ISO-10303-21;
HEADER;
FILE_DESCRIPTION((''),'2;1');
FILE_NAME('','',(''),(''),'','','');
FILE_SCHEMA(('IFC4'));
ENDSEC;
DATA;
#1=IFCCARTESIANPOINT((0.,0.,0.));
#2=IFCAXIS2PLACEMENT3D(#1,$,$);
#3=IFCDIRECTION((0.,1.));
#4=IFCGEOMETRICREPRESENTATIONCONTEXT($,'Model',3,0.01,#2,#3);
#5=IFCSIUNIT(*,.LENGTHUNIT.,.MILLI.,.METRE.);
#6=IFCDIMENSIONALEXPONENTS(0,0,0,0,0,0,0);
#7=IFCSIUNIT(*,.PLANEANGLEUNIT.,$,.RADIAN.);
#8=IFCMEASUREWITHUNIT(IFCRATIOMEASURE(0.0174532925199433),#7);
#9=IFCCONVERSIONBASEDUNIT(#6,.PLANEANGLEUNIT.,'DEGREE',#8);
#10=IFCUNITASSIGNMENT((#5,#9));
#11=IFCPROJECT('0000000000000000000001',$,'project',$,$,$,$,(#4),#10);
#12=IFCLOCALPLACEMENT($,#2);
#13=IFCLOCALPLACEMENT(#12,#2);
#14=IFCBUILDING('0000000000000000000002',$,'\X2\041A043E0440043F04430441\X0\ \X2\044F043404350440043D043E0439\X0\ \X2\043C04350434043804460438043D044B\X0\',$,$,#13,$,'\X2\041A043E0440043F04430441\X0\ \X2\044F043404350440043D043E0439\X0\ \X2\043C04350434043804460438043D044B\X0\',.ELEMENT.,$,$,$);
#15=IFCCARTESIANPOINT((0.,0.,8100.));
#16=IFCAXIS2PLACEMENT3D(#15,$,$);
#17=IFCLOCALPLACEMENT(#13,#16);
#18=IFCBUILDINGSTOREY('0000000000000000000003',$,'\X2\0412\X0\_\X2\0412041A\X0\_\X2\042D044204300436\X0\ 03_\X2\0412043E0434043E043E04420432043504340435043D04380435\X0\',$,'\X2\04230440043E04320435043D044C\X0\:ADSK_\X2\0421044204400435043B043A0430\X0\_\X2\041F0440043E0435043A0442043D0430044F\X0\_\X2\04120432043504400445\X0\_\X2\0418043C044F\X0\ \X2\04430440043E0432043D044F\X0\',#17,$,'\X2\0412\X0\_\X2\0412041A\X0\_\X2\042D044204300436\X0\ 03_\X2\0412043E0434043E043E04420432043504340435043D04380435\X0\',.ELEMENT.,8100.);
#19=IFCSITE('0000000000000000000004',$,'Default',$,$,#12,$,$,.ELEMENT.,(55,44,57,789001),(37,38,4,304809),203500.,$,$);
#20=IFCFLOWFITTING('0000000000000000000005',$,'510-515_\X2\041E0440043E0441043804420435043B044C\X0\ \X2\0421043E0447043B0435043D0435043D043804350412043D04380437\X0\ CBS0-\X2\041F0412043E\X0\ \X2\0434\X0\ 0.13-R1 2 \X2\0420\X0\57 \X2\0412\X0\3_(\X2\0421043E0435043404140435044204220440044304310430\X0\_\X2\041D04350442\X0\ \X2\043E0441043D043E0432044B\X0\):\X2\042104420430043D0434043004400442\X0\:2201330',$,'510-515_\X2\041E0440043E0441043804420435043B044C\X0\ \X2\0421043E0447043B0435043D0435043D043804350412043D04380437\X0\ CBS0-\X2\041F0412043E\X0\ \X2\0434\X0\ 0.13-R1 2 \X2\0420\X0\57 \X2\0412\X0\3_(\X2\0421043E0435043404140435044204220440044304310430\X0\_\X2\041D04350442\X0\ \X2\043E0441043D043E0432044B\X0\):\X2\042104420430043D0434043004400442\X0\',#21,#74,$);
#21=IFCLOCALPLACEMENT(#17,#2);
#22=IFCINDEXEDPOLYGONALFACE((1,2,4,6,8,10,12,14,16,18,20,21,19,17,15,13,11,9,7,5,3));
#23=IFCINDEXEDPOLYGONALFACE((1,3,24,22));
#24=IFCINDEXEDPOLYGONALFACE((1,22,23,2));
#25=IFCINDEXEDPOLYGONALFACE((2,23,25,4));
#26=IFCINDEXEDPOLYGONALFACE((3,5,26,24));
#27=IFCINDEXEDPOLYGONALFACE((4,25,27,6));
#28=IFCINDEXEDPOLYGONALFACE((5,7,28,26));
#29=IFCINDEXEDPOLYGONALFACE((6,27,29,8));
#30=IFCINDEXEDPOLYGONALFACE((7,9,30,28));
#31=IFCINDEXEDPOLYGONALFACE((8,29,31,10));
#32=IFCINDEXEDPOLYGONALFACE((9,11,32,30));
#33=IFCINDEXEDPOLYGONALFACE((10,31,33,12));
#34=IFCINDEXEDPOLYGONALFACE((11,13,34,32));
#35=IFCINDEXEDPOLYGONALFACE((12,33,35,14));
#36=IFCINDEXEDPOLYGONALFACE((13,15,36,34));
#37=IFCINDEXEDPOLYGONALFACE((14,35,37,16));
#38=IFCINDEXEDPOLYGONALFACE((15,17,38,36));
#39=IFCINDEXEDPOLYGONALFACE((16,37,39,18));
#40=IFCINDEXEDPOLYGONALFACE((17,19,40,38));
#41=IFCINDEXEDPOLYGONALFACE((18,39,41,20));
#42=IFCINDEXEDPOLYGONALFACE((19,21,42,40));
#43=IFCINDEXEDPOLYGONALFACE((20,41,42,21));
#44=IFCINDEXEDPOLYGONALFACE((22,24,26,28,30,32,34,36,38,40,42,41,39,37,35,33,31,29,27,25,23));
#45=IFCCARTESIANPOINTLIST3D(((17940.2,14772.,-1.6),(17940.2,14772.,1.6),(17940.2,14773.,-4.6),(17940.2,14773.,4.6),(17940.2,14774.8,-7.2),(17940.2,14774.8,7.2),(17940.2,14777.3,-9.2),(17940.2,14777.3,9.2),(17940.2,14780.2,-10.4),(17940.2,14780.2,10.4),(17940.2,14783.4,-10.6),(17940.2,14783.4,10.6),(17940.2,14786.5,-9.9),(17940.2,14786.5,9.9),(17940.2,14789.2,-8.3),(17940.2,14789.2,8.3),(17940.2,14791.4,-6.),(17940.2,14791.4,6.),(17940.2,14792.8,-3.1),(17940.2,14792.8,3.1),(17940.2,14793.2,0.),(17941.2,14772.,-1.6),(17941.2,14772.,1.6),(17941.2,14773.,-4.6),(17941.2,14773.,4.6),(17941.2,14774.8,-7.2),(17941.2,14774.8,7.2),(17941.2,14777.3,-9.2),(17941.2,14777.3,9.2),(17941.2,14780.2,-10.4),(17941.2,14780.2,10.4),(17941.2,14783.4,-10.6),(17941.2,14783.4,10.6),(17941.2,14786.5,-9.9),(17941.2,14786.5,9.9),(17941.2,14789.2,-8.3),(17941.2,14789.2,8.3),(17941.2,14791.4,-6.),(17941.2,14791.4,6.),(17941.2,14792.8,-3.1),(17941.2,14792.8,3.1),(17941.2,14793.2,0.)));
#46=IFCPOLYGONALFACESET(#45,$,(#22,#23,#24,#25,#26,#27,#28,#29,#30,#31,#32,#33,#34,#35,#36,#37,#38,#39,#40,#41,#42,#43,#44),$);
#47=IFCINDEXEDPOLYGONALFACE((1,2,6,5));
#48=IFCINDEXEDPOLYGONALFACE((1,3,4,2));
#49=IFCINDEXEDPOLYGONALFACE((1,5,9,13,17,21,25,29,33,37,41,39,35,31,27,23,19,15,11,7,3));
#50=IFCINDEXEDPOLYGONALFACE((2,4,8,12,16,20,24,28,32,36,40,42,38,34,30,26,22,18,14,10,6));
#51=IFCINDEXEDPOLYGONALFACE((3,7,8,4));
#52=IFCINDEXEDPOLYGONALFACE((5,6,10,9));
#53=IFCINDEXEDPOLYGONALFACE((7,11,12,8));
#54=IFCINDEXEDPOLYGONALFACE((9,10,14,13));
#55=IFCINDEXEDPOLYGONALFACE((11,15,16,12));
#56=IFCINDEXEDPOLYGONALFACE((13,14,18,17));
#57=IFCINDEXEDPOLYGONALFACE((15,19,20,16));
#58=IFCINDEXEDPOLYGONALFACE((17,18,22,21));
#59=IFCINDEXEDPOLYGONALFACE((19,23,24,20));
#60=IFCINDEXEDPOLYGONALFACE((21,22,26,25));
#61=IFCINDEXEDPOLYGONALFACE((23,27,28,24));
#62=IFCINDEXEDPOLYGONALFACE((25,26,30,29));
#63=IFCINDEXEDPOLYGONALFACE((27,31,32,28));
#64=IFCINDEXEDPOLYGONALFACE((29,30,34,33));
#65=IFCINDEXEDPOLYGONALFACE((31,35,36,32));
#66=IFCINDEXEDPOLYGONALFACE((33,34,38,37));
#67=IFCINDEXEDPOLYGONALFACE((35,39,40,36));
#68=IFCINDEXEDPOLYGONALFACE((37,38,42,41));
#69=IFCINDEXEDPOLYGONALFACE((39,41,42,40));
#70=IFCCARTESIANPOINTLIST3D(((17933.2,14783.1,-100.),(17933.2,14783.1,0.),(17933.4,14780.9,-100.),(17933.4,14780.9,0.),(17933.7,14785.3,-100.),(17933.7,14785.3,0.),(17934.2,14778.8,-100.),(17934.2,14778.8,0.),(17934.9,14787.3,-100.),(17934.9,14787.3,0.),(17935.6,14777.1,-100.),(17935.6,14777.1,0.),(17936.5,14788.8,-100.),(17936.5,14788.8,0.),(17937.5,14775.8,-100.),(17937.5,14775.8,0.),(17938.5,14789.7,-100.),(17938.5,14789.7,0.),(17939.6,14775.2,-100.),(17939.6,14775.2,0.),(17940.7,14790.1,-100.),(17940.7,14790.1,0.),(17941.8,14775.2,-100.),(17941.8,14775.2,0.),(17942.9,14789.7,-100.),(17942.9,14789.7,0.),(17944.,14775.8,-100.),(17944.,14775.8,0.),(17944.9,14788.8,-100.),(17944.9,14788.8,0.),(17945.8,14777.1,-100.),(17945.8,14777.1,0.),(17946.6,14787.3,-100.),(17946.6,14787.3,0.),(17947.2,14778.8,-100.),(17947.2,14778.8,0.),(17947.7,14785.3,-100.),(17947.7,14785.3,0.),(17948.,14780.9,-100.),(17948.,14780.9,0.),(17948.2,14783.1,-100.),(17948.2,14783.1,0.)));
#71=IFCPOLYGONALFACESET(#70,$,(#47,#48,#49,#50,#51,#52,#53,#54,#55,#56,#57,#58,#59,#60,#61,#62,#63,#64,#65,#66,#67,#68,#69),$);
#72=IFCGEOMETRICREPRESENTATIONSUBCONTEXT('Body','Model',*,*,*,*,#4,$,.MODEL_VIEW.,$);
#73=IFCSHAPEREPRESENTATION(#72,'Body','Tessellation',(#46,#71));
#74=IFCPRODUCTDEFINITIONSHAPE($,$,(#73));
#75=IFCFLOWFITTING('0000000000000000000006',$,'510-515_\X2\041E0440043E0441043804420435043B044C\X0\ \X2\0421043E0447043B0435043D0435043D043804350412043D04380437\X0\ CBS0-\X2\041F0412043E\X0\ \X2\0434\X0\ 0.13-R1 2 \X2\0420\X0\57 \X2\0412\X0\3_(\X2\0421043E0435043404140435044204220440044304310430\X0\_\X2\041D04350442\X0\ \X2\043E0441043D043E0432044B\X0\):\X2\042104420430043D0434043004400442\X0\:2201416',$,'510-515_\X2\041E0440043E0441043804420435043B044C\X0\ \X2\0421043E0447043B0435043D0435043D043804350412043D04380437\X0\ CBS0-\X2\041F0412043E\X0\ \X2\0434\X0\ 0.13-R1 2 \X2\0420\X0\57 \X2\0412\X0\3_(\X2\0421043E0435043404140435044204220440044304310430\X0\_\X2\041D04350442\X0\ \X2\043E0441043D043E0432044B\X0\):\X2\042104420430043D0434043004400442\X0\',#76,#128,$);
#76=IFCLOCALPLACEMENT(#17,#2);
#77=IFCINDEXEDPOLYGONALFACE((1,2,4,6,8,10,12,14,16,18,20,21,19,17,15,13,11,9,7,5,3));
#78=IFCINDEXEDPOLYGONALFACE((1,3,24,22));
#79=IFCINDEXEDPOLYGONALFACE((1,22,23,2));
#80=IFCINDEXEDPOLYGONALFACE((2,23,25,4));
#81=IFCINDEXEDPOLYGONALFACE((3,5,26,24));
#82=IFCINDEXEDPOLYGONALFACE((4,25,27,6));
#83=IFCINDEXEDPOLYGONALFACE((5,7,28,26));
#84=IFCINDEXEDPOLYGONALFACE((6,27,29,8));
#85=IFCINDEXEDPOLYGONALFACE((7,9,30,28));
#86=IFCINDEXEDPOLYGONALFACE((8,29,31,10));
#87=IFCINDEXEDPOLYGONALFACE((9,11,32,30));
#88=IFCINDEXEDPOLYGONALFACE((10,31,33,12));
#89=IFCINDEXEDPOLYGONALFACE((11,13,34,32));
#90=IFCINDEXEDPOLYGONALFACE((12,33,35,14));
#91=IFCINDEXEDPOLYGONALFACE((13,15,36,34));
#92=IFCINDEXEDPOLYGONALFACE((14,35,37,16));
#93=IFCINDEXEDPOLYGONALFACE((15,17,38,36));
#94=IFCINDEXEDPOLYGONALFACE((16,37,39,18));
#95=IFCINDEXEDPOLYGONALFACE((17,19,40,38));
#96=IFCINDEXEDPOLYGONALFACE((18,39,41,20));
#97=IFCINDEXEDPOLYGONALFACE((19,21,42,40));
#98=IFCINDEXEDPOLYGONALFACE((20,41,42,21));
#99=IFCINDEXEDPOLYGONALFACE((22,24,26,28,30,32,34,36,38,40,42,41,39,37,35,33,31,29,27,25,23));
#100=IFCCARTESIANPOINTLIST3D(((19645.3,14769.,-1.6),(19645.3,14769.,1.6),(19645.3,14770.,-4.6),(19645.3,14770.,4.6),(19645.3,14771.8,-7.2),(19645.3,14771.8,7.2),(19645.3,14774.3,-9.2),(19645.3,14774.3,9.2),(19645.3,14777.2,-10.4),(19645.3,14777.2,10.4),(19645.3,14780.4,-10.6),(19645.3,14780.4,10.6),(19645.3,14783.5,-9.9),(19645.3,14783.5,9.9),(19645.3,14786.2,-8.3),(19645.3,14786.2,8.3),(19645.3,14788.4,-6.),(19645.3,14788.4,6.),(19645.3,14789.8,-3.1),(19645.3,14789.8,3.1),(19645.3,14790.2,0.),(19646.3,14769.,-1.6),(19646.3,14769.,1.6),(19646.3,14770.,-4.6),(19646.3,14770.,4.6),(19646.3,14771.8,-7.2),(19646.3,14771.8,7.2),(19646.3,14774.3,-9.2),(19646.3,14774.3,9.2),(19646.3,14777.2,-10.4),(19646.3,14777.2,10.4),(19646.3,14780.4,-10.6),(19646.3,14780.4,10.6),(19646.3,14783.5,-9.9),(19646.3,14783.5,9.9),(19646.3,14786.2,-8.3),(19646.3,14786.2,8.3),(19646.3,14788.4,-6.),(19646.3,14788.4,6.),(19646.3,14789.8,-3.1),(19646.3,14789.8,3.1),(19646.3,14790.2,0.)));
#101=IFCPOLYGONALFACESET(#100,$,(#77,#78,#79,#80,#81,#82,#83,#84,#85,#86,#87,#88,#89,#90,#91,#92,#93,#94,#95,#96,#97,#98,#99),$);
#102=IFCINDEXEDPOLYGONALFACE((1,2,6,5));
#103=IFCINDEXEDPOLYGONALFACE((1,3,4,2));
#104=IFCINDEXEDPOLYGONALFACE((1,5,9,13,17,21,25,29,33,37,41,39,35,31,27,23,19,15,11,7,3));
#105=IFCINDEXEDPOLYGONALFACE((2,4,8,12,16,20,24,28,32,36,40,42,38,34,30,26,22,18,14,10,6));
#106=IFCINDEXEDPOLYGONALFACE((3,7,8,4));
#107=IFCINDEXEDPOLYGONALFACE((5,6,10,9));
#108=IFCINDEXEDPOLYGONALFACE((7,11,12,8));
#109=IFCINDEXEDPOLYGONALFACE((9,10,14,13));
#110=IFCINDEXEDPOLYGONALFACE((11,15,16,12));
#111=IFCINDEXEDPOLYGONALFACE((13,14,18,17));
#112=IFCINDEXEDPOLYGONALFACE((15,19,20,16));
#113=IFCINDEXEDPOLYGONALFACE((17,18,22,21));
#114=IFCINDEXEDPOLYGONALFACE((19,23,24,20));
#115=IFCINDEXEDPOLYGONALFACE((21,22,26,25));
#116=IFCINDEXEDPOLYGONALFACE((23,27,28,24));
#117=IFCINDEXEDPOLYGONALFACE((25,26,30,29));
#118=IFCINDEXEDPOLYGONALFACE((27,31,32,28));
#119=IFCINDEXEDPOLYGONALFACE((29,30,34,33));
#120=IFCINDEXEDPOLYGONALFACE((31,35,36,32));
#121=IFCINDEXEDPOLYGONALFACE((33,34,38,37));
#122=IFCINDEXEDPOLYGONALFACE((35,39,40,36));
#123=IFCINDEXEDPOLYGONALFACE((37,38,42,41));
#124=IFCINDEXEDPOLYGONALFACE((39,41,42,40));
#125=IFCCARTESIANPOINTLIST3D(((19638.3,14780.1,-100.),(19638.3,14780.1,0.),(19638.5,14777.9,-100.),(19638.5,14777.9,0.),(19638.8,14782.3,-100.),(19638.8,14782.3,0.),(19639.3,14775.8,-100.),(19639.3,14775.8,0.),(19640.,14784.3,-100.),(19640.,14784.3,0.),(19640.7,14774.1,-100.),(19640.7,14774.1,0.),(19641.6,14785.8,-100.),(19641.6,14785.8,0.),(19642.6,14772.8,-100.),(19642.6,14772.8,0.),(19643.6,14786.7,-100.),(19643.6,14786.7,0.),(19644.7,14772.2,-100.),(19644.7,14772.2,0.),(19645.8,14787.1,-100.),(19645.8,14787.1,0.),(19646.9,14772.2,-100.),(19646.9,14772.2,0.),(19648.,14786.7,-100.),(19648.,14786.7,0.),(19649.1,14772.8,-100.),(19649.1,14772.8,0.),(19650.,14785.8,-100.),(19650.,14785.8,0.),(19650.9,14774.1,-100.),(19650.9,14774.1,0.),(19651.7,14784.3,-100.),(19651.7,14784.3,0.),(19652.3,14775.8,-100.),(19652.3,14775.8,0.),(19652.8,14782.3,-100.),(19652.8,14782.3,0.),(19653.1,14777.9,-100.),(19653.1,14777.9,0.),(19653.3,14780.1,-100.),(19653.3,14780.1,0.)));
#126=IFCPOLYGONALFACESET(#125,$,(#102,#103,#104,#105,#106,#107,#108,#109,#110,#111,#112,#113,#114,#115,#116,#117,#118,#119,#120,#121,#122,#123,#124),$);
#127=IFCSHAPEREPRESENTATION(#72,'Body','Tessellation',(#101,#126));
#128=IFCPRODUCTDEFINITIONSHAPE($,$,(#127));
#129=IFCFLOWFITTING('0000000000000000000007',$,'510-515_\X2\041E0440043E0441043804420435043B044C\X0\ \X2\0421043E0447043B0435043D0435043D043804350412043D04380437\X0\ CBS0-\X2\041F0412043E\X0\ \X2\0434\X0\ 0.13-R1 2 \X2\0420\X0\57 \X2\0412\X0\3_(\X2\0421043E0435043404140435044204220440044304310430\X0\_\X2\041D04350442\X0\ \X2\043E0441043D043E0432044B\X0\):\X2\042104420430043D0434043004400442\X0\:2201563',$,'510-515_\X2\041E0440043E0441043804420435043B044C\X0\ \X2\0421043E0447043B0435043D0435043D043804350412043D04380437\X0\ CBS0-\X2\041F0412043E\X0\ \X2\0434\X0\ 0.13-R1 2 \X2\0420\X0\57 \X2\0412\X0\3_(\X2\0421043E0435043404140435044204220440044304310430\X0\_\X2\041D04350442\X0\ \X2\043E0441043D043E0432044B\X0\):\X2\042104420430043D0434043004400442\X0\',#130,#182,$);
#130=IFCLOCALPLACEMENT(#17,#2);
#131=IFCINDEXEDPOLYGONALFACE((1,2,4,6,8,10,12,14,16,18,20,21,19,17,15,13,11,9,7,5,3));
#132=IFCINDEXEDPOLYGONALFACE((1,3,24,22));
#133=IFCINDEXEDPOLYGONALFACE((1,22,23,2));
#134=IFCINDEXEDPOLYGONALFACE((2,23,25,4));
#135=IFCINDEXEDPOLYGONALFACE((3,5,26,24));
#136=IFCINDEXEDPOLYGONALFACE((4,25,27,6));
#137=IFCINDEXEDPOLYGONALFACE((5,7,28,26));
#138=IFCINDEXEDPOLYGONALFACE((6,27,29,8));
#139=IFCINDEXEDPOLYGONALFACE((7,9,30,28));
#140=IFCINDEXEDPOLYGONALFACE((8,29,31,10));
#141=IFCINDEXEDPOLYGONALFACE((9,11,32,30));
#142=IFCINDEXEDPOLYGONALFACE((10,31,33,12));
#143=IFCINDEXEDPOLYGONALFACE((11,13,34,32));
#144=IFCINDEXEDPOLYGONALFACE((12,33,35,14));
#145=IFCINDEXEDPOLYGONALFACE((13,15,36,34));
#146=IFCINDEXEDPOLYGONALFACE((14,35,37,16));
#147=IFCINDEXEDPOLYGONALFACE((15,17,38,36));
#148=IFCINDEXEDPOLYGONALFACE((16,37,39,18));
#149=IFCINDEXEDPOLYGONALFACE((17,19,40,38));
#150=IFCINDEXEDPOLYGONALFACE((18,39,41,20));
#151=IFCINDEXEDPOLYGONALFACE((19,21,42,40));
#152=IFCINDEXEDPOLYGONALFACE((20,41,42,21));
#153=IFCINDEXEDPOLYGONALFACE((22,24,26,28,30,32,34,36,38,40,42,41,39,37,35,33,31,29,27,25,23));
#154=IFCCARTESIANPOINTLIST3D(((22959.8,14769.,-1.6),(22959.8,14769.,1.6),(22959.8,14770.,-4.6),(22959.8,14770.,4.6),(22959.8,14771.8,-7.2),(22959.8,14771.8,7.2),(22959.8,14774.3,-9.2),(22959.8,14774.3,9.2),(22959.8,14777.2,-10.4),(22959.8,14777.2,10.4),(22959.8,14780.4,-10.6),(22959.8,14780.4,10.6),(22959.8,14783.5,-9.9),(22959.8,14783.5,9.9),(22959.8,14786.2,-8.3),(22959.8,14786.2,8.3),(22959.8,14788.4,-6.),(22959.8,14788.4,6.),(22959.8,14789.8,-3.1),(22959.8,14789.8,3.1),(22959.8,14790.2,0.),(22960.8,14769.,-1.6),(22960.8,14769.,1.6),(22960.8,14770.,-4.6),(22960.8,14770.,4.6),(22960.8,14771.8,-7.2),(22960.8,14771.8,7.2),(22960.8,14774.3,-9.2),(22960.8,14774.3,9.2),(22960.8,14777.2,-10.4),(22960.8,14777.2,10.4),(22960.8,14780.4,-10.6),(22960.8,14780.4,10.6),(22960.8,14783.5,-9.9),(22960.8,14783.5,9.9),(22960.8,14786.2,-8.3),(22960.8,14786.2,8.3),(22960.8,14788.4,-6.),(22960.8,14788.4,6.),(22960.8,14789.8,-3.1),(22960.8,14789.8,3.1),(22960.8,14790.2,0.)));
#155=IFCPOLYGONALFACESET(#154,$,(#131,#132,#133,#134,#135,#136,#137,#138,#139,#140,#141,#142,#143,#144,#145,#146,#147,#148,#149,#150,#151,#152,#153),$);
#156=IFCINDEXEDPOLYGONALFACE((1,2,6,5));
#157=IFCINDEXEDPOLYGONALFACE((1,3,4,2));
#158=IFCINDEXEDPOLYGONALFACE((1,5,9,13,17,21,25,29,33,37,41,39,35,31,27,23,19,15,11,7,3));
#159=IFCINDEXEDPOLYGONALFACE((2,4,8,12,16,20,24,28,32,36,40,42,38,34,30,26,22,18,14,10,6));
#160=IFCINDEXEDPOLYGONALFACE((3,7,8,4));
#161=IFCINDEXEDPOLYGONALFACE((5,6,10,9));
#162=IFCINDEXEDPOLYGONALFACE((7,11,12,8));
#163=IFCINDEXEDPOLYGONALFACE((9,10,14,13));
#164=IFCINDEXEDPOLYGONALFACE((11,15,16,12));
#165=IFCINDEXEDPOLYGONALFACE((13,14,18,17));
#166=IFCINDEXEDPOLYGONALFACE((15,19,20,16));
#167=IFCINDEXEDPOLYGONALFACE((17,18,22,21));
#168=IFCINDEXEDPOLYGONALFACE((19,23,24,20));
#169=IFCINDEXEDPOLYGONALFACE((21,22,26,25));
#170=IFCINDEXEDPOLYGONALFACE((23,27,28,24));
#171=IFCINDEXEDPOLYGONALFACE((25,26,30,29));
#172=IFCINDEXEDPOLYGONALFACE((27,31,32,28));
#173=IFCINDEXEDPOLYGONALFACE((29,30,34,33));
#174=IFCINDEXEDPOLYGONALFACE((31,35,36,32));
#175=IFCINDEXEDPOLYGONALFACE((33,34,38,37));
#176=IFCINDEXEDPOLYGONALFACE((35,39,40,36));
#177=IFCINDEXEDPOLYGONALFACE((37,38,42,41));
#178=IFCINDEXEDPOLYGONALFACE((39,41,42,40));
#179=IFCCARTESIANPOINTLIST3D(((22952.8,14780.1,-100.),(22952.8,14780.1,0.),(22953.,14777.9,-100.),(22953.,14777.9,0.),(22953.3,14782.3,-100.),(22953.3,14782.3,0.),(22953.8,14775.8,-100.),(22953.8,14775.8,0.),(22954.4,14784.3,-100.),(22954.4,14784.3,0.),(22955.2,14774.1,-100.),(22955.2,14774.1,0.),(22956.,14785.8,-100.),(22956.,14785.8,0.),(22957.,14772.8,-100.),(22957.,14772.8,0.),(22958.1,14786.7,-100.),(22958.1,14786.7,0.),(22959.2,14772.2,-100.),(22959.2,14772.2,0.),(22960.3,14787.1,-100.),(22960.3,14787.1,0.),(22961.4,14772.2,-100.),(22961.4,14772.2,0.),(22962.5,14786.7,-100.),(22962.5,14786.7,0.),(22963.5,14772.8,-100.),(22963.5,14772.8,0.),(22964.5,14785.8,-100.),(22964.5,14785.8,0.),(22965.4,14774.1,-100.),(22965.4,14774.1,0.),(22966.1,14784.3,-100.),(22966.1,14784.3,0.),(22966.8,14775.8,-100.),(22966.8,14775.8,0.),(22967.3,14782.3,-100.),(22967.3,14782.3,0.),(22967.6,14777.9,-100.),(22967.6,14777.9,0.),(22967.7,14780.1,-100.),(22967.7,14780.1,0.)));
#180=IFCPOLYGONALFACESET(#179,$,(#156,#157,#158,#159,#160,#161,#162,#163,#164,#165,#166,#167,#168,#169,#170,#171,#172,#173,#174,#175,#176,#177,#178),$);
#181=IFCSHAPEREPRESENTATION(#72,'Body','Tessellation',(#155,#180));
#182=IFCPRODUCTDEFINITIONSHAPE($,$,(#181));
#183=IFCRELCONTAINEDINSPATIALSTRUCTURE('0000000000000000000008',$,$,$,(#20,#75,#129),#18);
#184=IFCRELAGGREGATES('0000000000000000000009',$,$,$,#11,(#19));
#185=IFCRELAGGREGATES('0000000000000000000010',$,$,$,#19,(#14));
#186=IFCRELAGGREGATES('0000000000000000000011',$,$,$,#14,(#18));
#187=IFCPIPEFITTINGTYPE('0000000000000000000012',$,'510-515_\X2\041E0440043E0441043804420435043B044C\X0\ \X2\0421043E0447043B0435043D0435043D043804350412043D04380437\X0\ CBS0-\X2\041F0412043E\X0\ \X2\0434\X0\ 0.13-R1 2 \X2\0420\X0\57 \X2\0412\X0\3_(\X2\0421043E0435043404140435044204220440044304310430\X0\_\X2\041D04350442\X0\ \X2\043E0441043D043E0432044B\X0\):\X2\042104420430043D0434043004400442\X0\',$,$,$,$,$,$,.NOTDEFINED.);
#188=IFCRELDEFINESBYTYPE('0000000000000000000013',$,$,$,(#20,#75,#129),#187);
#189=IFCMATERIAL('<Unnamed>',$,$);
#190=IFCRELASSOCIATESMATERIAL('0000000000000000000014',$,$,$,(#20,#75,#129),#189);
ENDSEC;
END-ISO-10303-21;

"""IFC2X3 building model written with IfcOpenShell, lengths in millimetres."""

from ifc_helpers import new_model, entity, si_unit, converted_unit, direction, frame, origin, origin_2d_with_axis, place, context, subcontext, project, spatial, circle, extrude, source, transform, mapped, material, type_object, type_shapes, element, save


model = new_model("IFC2X3")

# Units and contexts
model_context = context("Model", 3, precision=0.01, world=origin(), true_north=direction((0.0, 1.0)))
body_context = subcontext(model_context, "Body", "Model", "MODEL_VIEW")
ifc_project = project(units=[si_unit("LENGTHUNIT", "METRE", prefix="MILLI"), converted_unit("PLANEANGLEUNIT", "DEGREE", entity("IfcRatioMeasure", 0.0174532925199433), si_unit("PLANEANGLEUNIT", "RADIAN"), dimensions=[0, 0, 0, 0, 0, 0, 0])], contexts=[model_context])

# Site, building, storey
site_placement = place(None, origin())
site = spatial("IfcSite", under=ifc_project, at=site_placement, Name="Default", CompositionType="ELEMENT", RefLatitude=(55, 44, 57, 789001), RefLongitude=(37, 38, 4, 304809), RefElevation=203500.0)
building_placement = place(site_placement, origin())
building = spatial("IfcBuilding", under=site, at=building_placement, Name="Корпус ядерной медицины", LongName="Корпус ядерной медицины", CompositionType="ELEMENT")
storey_placement = place(building_placement, frame((0.0, 0.0, 8100.0)))
storey = spatial("IfcBuildingStorey", under=building, at=storey_placement, Name="В_ВК_Этаж 03_Водоотведение", ObjectType="Уровень:ADSK_Стрелка_Проектная_Вверх_Имя уровня", LongName="В_ВК_Этаж 03_Водоотведение", CompositionType="ELEMENT", Elevation=8100.0)

# Flow fittings
ifc_material_1 = material(Name="<Unnamed>")
pipe_fitting_type_1 = type_object("IfcPipeFittingType", Name="510-515_Ороситель СочленениеВниз CBS0-ПВо д 0.13-R1 2 Р57 В3_(СоедДетТруба_Нет основы):Стандарт", PredefinedType="NOTDEFINED")
shared_shape_1 = source(origin(), body_context, "Body", "SweptSolid", [
    extrude(circle(Radius=10.7, at=origin_2d_with_axis()), frame((-0.5, 0.0, 0.0), z_axis=(1.0, 0.0, 0.0), x_axis=(0.0, 1.0, 0.0)), (0.0, 0.0, 1.0), 1.0),
    extrude(circle(Radius=7.5, at=origin_2d_with_axis()), frame((0.0, 0.0, -100.0), z_axis=(0.0, 0.0, 1.0), x_axis=(0.0, 1.0, 0.0)), (0.0, 0.0, 1.0), 100.0),
])
type_shapes(pipe_fitting_type_1, [shared_shape_1])
for number, where, name in (
    (1, (17940.7, 14782.6, 0.0), "510-515_Ороситель СочленениеВниз CBS0-ПВо д 0.13-R1 2 Р57 В3_(СоедДетТруба_Нет основы):Стандарт:2201330"),
    (2, (19645.8, 14779.6, 0.0), "510-515_Ороситель СочленениеВниз CBS0-ПВо д 0.13-R1 2 Р57 В3_(СоедДетТруба_Нет основы):Стандарт:2201416"),
    (3, (22960.3, 14779.6, 0.0), "510-515_Ороситель СочленениеВниз CBS0-ПВо д 0.13-R1 2 Р57 В3_(СоедДетТруба_Нет основы):Стандарт:2201563"),
):
    element("IfcFlowFitting", number, at=place(storey_placement, frame(where)), inside=storey, type_object=pipe_fitting_type_1, material=ifc_material_1, Name=name, ObjectType="510-515_Ороситель СочленениеВниз CBS0-ПВо д 0.13-R1 2 Р57 В3_(СоедДетТруба_Нет основы):Стандарт", context=body_context, shape_type="MappedRepresentation", body=[
        mapped(shared_shape_1, transform((0.0, 0.0, 0.0), scale=1.0)),
    ])

save(model, "model.ifc")
